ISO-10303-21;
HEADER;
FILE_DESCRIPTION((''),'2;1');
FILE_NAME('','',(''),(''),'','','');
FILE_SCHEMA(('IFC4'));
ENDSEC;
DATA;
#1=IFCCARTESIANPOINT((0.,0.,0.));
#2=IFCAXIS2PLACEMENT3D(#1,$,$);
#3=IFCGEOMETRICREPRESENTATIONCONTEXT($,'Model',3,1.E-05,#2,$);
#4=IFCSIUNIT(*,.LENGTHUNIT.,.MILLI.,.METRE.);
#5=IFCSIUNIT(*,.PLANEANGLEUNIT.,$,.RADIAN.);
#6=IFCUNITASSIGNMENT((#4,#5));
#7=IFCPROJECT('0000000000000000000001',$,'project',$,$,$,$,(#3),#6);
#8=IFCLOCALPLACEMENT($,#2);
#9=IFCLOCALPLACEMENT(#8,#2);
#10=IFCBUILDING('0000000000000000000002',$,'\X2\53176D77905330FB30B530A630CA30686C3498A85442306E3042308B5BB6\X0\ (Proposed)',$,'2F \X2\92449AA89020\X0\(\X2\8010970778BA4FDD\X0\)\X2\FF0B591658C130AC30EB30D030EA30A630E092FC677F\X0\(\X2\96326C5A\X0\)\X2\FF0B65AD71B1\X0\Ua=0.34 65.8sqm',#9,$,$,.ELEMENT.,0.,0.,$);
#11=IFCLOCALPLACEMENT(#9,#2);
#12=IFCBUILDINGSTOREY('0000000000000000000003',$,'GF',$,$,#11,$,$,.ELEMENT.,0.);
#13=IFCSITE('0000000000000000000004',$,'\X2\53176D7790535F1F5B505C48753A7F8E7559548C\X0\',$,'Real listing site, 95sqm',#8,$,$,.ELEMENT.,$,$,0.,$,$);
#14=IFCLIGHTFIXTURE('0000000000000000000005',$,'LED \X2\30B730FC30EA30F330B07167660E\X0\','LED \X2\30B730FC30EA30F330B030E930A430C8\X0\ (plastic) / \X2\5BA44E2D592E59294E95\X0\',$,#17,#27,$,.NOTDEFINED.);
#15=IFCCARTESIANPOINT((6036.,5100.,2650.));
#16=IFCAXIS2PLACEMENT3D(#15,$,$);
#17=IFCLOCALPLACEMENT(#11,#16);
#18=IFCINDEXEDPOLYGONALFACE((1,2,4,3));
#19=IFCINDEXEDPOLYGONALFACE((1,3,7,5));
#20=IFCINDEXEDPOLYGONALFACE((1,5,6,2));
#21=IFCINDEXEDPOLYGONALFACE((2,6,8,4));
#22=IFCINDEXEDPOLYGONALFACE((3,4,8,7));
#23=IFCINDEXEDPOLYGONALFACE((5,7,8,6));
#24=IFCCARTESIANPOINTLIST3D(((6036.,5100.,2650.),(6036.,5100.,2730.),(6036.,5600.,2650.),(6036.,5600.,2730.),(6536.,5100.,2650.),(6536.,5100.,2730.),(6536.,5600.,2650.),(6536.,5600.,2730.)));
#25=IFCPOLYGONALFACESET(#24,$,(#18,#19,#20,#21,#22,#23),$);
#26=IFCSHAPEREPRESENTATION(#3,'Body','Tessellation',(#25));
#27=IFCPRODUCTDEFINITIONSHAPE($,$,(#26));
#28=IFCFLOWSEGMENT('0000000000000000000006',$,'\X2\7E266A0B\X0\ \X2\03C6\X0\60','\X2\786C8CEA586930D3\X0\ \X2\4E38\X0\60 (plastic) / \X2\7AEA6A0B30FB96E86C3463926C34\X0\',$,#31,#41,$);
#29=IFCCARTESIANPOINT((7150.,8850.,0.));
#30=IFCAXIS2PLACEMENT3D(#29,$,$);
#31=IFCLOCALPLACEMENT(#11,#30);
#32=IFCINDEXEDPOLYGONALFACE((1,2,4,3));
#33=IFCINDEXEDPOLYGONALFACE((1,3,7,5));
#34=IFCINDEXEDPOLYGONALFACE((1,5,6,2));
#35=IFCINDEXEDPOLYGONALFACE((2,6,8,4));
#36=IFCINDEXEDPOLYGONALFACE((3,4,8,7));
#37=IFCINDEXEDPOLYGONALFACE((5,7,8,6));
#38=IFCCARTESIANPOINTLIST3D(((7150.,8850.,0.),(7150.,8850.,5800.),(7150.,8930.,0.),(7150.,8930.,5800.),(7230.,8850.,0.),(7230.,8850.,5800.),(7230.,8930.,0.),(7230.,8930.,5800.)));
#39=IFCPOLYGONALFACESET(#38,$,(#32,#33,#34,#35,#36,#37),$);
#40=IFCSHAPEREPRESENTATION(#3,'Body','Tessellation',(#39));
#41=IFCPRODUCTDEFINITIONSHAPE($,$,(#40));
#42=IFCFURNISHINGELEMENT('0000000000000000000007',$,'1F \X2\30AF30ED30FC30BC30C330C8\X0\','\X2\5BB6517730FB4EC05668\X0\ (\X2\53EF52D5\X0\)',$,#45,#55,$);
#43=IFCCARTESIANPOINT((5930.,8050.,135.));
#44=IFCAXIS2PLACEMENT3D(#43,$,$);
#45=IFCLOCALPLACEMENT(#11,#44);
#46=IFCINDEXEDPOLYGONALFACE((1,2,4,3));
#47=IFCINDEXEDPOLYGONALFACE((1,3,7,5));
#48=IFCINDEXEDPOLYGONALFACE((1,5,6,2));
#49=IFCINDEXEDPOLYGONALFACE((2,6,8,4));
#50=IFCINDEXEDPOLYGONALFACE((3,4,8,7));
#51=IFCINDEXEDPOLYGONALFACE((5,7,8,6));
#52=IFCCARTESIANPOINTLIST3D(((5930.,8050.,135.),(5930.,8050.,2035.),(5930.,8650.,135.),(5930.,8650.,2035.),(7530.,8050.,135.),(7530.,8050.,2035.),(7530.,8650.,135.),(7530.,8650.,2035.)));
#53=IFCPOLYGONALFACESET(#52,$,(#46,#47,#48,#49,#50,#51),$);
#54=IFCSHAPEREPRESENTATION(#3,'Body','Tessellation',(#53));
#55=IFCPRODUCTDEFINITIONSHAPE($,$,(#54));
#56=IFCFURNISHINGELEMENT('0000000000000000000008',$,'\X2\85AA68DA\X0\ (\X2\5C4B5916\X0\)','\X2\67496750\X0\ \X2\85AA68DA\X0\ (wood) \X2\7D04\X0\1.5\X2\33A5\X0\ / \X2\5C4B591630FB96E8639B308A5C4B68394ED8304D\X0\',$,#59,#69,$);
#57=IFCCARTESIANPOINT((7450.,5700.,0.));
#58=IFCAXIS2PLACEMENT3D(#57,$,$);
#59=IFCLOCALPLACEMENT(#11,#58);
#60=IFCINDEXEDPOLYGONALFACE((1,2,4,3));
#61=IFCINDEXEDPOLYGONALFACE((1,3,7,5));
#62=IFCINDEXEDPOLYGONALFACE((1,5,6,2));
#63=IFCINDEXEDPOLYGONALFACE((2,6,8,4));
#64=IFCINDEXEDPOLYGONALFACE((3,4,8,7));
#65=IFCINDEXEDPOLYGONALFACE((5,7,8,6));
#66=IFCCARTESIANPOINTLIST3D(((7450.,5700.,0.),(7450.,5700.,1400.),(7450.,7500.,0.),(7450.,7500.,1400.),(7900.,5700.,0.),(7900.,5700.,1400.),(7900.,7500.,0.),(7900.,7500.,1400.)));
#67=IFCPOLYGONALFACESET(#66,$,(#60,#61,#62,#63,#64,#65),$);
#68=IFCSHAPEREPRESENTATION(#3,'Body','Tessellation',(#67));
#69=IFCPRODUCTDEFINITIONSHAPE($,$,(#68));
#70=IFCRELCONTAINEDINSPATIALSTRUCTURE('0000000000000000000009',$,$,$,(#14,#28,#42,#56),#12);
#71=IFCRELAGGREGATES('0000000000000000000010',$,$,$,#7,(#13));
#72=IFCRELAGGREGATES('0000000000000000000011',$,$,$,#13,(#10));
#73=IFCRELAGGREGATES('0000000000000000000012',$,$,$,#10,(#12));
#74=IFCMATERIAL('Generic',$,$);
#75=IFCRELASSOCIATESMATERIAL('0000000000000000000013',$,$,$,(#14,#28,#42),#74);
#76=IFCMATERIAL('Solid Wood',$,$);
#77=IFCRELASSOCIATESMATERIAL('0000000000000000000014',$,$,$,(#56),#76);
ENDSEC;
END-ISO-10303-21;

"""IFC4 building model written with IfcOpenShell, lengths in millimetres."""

from ifc_helpers import new_model, si_unit, frame, frame_2d, origin, place, context, project, spatial, rectangle, extrude, material, element, save


model = new_model("IFC4")

# Units and contexts
model_context = context("Model", 3, precision=1e-05, world=origin())
ifc_project = project(units=[si_unit("LENGTHUNIT", "METRE", prefix="MILLI"), si_unit("PLANEANGLEUNIT", "RADIAN")], contexts=[model_context])

# Site, building, storey
site_placement = place(None, origin())
site = spatial("IfcSite", under=ifc_project, at=site_placement, Name="北海道弟子屈町美留和", ObjectType="Real listing site, 95sqm", CompositionType="ELEMENT", RefElevation=0.0)
building_placement = place(site_placement, origin())
building = spatial("IfcBuilding", under=site, at=building_placement, Name="北海道・サウナと水風呂のある家 (Proposed)", ObjectType="2F 鉄骨造(耐震確保)＋外壁ガルバリウム鋼板(防汚)＋断熱Ua=0.34 65.8sqm", CompositionType="ELEMENT", ElevationOfRefHeight=0.0, ElevationOfTerrain=0.0)
storey_placement = place(building_placement, origin())
storey = spatial("IfcBuildingStorey", under=building, at=storey_placement, Name="GF", CompositionType="ELEMENT", Elevation=0.0)

# Shared definitions
ifc_material_1 = material(Name="Solid Wood")

# Shared definitions
ifc_material_2 = material(Name="Generic")

# Light fixture
light_fixture_placement = place(storey_placement, frame((6036.0, 5100.0, 2650.0)))
element("IfcLightFixture", 1, at=light_fixture_placement, inside=storey, material=ifc_material_2, Name="LED シーリング照明", Description="LED シーリングライト (plastic) / 室中央天井", PredefinedType="NOTDEFINED", context=model_context, shape_type="SweptSolid", body=[
    extrude(rectangle(XDim=500.0, YDim=500.0, at=frame_2d((250.0, 250.0))), frame((6036.0, 5100.0, 2650.0)), (0.0, 0.0, 1.0), 80.0),
])

# Flow segment
flow_segment_placement = place(storey_placement, frame((7150.0, 8850.0, 0.0)))
element("IfcFlowSegment", 2, at=flow_segment_placement, inside=storey, material=ifc_material_2, Name="縦樋 φ60", Description="硬質塩ビ 丸60 (plastic) / 竪樋・雨水排水", context=model_context, shape_type="SweptSolid", body=[
    extrude(rectangle(XDim=80.0, YDim=80.0, at=frame_2d((40.0, 40.0))), frame((7150.0, 8850.0, 0.0)), (0.0, 0.0, 1.0), 5800.0),
])

# Furnishing elements
furnishing_1_placement = place(storey_placement, frame((5930.0, 8050.0, 135.0)))
element("IfcFurnishingElement", 3, at=furnishing_1_placement, inside=storey, material=ifc_material_2, Name="1F クローゼット", Description="家具・什器 (可動)", context=model_context, shape_type="SweptSolid", body=[
    extrude(rectangle(XDim=1600.0, YDim=600.0, at=frame_2d((800.0, 300.0))), frame((5930.0, 8050.0, 135.0)), (0.0, 0.0, 1.0), 1900.0),
])
furnishing_2_placement = place(storey_placement, frame((7450.0, 5700.0, 0.0)))
element("IfcFurnishingElement", 4, at=furnishing_2_placement, inside=storey, material=ifc_material_1, Name="薪棚 (屋外)", Description="杉材 薪棚 (wood) 約1.5㎥ / 屋外・雨掛り屋根付き", context=model_context, shape_type="SweptSolid", body=[
    extrude(rectangle(XDim=450.0, YDim=1800.0, at=frame_2d((225.0, 900.0))), frame((7450.0, 5700.0, 0.0)), (0.0, 0.0, 1.0), 1400.0),
])

save(model, "model.ifc")
